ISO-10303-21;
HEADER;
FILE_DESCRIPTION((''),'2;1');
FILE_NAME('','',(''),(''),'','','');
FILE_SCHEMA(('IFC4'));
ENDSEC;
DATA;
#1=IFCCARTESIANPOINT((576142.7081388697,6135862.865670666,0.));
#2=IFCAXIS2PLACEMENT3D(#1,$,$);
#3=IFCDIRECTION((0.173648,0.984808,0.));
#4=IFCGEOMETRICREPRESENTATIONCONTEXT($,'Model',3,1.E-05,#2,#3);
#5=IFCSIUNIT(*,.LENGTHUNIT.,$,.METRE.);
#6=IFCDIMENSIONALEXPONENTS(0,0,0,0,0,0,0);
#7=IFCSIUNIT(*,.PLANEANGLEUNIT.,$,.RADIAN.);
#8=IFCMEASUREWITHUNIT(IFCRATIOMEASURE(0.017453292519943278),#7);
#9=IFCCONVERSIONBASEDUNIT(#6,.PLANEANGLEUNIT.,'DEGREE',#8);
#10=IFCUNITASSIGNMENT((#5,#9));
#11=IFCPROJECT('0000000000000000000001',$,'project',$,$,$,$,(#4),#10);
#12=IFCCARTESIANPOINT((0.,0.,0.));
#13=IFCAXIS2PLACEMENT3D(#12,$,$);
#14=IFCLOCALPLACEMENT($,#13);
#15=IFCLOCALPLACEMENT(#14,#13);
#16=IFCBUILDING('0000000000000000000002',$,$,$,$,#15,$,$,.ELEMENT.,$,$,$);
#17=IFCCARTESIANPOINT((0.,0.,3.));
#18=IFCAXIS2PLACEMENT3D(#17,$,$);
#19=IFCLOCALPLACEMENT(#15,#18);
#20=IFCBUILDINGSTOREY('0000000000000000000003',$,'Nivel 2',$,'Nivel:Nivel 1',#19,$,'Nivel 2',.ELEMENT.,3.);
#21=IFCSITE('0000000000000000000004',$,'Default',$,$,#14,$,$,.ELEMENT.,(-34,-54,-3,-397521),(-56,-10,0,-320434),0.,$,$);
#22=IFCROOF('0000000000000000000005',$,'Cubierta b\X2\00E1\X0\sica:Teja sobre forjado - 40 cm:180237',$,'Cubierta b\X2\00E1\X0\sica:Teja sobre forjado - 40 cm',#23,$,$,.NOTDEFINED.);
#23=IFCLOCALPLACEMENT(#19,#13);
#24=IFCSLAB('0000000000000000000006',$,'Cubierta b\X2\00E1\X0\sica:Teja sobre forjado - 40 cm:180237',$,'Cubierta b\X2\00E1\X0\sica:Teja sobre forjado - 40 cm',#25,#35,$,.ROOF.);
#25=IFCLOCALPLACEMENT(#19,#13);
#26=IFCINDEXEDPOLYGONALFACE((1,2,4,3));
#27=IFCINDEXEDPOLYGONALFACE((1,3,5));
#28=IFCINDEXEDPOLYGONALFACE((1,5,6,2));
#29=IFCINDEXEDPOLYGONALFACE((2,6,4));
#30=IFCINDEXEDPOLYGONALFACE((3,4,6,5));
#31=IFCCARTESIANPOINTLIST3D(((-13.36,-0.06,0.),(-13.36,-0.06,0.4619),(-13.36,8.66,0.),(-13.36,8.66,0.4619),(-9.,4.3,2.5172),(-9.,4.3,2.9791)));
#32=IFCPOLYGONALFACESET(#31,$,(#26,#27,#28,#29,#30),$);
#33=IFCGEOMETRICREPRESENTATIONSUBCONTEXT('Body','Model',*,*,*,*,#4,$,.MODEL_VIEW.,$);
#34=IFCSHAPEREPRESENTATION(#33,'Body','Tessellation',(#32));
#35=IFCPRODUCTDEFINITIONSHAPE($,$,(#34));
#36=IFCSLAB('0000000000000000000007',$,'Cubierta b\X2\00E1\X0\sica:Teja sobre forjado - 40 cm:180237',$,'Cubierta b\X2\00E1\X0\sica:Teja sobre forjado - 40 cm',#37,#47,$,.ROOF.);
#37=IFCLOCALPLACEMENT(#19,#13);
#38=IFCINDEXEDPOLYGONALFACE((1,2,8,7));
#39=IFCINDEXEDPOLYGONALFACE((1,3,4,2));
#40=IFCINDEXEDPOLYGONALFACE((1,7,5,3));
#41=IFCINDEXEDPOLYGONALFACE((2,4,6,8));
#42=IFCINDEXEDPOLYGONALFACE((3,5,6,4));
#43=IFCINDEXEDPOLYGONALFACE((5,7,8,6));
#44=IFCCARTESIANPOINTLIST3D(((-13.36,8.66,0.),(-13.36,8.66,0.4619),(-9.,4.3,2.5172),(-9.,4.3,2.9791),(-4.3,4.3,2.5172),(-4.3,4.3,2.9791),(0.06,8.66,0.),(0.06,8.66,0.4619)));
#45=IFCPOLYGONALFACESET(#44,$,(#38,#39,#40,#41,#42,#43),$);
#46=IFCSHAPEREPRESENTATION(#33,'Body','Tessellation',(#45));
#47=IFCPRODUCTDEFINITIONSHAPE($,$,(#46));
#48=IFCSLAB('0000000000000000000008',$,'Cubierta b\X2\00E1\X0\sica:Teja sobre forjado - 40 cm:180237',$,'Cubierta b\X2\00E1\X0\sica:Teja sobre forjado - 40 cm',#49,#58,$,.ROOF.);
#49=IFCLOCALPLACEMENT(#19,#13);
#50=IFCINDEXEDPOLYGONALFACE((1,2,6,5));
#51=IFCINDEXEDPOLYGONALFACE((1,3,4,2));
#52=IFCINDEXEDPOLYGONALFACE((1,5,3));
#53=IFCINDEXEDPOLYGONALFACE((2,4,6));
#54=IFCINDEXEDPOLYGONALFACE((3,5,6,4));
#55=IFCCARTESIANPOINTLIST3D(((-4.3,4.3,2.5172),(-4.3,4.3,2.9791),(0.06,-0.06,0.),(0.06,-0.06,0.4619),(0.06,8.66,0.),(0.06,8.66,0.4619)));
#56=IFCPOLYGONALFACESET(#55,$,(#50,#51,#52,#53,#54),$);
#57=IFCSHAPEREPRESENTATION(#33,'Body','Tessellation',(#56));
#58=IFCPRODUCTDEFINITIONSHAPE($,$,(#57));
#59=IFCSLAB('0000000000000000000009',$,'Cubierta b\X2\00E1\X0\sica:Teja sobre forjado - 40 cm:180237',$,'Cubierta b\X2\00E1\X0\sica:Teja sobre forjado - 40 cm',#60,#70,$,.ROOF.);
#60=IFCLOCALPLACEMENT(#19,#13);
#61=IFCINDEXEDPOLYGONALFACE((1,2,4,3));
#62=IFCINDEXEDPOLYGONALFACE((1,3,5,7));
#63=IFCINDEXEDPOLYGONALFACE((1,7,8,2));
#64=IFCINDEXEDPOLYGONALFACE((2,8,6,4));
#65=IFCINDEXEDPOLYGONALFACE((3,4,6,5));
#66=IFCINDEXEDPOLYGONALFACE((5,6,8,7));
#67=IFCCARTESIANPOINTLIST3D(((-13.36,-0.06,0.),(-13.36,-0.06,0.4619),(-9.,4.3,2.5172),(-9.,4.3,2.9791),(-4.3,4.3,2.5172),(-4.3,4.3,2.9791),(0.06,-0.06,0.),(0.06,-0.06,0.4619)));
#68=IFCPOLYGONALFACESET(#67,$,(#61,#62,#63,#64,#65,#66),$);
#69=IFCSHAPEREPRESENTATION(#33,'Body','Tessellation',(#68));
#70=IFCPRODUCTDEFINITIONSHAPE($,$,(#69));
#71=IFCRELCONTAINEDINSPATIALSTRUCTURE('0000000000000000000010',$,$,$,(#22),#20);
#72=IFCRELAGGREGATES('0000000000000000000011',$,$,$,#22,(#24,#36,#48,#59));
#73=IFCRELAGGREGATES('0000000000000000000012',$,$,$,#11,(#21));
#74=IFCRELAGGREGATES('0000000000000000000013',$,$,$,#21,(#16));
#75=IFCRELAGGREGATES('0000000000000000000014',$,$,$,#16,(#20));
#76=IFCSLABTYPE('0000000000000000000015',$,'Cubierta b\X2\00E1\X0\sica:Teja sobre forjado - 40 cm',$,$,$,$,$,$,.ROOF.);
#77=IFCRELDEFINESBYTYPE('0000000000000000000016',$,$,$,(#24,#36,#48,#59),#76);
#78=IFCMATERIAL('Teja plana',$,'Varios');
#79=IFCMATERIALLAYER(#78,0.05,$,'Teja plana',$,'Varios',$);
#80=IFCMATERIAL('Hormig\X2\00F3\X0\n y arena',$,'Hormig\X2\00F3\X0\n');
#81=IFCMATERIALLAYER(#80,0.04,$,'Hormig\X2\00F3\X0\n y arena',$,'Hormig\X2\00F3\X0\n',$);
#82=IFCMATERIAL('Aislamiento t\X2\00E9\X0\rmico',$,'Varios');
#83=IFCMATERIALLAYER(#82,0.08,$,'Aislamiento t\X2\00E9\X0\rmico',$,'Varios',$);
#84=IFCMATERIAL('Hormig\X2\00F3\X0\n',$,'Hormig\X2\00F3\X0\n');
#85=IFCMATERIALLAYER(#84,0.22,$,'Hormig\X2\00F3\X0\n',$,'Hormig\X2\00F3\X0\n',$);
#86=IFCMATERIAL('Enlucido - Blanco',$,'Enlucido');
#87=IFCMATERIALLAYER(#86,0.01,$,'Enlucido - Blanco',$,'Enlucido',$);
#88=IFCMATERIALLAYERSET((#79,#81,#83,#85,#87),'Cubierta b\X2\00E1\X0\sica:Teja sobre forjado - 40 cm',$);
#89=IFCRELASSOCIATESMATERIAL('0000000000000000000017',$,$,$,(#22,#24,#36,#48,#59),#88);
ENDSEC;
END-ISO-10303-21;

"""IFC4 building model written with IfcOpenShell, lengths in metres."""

from ifc_helpers import new_model, entity, si_unit, converted_unit, direction, frame, origin, place, context, subcontext, project, spatial, polyline, outline, extrude, material, layer, layer_set, type_object, element, aggregate, save


model = new_model("IFC4")

# Units and contexts
model_context = context("Model", 3, precision=1e-05, world=frame((576142.7081388697, 6135862.865670666, 0.0)), true_north=direction((0.173648, 0.984808, 0.0)))
body_context = subcontext(model_context, "Body", "Model", "MODEL_VIEW")
ifc_project = project(units=[si_unit("LENGTHUNIT", "METRE"), converted_unit("PLANEANGLEUNIT", "DEGREE", entity("IfcRatioMeasure", 0.017453292519943278), si_unit("PLANEANGLEUNIT", "RADIAN"), dimensions=[0, 0, 0, 0, 0, 0, 0])], contexts=[model_context])

# Site, building, storey
site_placement = place(None, origin())
site = spatial("IfcSite", under=ifc_project, at=site_placement, Name="Default", CompositionType="ELEMENT", RefLatitude=(-34, -54, -3, -397521), RefLongitude=(-56, -10, 0, -320434), RefElevation=0.0)
building_placement = place(site_placement, origin())
building = spatial("IfcBuilding", under=site, at=building_placement, CompositionType="ELEMENT")
storey_placement = place(building_placement, frame((0.0, 0.0, 3.0)))
storey = spatial("IfcBuildingStorey", under=building, at=storey_placement, Name="Nivel 2", ObjectType="Nivel:Nivel 1", LongName="Nivel 2", CompositionType="ELEMENT", Elevation=3.0)

# Roof, slabs
ifc_material_1 = material(Name="Teja plana", Category="Varios")
ifc_layer_1 = layer(ifc_material_1, 0.05, Name="Teja plana", Category="Varios")
ifc_material_2 = material(Name="Hormigón y arena", Category="Hormigón")
ifc_layer_2 = layer(ifc_material_2, 0.04, Name="Hormigón y arena", Category="Hormigón")
ifc_material_3 = material(Name="Aislamiento térmico", Category="Varios")
ifc_layer_3 = layer(ifc_material_3, 0.08, Name="Aislamiento térmico", Category="Varios")
ifc_material_4 = material(Name="Hormigón", Category="Hormigón")
ifc_layer_4 = layer(ifc_material_4, 0.22, Name="Hormigón", Category="Hormigón")
ifc_material_5 = material(Name="Enlucido - Blanco", Category="Enlucido")
ifc_layer_5 = layer(ifc_material_5, 0.01, Name="Enlucido - Blanco", Category="Enlucido")
ifc_layer_set = layer_set([ifc_layer_1, ifc_layer_2, ifc_layer_3, ifc_layer_4, ifc_layer_5], Name="Cubierta básica:Teja sobre forjado - 40 cm")
roof_placement = place(storey_placement, frame((-13.36, -0.06, 0.0)))
roof = element("IfcRoof", 1, at=roof_placement, inside=storey, material=ifc_layer_set, Name="Cubierta básica:Teja sobre forjado - 40 cm:180237", ObjectType="Cubierta básica:Teja sobre forjado - 40 cm", PredefinedType="NOTDEFINED")
slab_type = type_object("IfcSlabType", Name="Cubierta básica:Teja sobre forjado - 40 cm", PredefinedType="ROOF")
slab_1_placement = place(roof_placement, origin())
slab_1 = element("IfcSlab", 2, at=slab_1_placement, type_object=slab_type, material=ifc_layer_set, Name="Cubierta básica:Teja sobre forjado - 40 cm:180237", ObjectType="Cubierta básica:Teja sobre forjado - 40 cm", PredefinedType="ROOF", context=body_context, shape_type="SweptSolid", body=[
    extrude(outline(polyline([(-2.5172, 4.36), (-2.5172, -4.36), (2.5172, 0.0), (-2.5172, 4.36)])), frame((2.18, 4.36, 1.2586), z_axis=(-0.5, 0.0, 0.866025), x_axis=(0.866025, 0.0, 0.5)), (0.5, 0.0, 0.866025), 0.4619),
])
slab_2_placement = place(roof_placement, origin())
slab_2 = element("IfcSlab", 3, at=slab_2_placement, type_object=slab_type, material=ifc_layer_set, Name="Cubierta básica:Teja sobre forjado - 40 cm:180237", ObjectType="Cubierta básica:Teja sobre forjado - 40 cm", PredefinedType="ROOF", context=body_context, shape_type="SweptSolid", body=[
    extrude(outline(polyline([(-2.35, -2.5172), (2.35, -2.5172), (6.71, 2.5172), (-6.71, 2.5172), (-2.35, -2.5172)])), frame((6.71, 6.54, 1.2586), z_axis=(0.0, 0.5, 0.866025), x_axis=(1.0, 0.0, 0.0)), (0.0, -0.5, 0.866025), 0.4619),
])
slab_3_placement = place(roof_placement, origin())
slab_3 = element("IfcSlab", 4, at=slab_3_placement, type_object=slab_type, material=ifc_layer_set, Name="Cubierta básica:Teja sobre forjado - 40 cm:180237", ObjectType="Cubierta básica:Teja sobre forjado - 40 cm", PredefinedType="ROOF", context=body_context, shape_type="SweptSolid", body=[
    extrude(outline(polyline([(2.5172, -4.36), (2.5172, 4.36), (-2.5172, 0.0), (2.5172, -4.36)])), frame((11.24, 4.36, 1.2586), z_axis=(0.5, 0.0, 0.866025), x_axis=(0.866025, 0.0, -0.5)), (-0.5, 0.0, 0.866025), 0.4619),
])
slab_4_placement = place(roof_placement, origin())
slab_4 = element("IfcSlab", 5, at=slab_4_placement, type_object=slab_type, material=ifc_layer_set, Name="Cubierta básica:Teja sobre forjado - 40 cm:180237", ObjectType="Cubierta básica:Teja sobre forjado - 40 cm", PredefinedType="ROOF", context=body_context, shape_type="SweptSolid", body=[
    extrude(outline(polyline([(-6.71, -2.5172), (6.71, -2.5172), (2.35, 2.5172), (-2.35, 2.5172), (-6.71, -2.5172)])), frame((6.71, 2.18, 1.2586), z_axis=(0.0, -0.5, 0.866025), x_axis=(1.0, 0.0, 0.0)), (0.0, 0.5, 0.866025), 0.4619),
])
aggregate(roof, [slab_1, slab_2, slab_3, slab_4])

save(model, "model.ifc")
